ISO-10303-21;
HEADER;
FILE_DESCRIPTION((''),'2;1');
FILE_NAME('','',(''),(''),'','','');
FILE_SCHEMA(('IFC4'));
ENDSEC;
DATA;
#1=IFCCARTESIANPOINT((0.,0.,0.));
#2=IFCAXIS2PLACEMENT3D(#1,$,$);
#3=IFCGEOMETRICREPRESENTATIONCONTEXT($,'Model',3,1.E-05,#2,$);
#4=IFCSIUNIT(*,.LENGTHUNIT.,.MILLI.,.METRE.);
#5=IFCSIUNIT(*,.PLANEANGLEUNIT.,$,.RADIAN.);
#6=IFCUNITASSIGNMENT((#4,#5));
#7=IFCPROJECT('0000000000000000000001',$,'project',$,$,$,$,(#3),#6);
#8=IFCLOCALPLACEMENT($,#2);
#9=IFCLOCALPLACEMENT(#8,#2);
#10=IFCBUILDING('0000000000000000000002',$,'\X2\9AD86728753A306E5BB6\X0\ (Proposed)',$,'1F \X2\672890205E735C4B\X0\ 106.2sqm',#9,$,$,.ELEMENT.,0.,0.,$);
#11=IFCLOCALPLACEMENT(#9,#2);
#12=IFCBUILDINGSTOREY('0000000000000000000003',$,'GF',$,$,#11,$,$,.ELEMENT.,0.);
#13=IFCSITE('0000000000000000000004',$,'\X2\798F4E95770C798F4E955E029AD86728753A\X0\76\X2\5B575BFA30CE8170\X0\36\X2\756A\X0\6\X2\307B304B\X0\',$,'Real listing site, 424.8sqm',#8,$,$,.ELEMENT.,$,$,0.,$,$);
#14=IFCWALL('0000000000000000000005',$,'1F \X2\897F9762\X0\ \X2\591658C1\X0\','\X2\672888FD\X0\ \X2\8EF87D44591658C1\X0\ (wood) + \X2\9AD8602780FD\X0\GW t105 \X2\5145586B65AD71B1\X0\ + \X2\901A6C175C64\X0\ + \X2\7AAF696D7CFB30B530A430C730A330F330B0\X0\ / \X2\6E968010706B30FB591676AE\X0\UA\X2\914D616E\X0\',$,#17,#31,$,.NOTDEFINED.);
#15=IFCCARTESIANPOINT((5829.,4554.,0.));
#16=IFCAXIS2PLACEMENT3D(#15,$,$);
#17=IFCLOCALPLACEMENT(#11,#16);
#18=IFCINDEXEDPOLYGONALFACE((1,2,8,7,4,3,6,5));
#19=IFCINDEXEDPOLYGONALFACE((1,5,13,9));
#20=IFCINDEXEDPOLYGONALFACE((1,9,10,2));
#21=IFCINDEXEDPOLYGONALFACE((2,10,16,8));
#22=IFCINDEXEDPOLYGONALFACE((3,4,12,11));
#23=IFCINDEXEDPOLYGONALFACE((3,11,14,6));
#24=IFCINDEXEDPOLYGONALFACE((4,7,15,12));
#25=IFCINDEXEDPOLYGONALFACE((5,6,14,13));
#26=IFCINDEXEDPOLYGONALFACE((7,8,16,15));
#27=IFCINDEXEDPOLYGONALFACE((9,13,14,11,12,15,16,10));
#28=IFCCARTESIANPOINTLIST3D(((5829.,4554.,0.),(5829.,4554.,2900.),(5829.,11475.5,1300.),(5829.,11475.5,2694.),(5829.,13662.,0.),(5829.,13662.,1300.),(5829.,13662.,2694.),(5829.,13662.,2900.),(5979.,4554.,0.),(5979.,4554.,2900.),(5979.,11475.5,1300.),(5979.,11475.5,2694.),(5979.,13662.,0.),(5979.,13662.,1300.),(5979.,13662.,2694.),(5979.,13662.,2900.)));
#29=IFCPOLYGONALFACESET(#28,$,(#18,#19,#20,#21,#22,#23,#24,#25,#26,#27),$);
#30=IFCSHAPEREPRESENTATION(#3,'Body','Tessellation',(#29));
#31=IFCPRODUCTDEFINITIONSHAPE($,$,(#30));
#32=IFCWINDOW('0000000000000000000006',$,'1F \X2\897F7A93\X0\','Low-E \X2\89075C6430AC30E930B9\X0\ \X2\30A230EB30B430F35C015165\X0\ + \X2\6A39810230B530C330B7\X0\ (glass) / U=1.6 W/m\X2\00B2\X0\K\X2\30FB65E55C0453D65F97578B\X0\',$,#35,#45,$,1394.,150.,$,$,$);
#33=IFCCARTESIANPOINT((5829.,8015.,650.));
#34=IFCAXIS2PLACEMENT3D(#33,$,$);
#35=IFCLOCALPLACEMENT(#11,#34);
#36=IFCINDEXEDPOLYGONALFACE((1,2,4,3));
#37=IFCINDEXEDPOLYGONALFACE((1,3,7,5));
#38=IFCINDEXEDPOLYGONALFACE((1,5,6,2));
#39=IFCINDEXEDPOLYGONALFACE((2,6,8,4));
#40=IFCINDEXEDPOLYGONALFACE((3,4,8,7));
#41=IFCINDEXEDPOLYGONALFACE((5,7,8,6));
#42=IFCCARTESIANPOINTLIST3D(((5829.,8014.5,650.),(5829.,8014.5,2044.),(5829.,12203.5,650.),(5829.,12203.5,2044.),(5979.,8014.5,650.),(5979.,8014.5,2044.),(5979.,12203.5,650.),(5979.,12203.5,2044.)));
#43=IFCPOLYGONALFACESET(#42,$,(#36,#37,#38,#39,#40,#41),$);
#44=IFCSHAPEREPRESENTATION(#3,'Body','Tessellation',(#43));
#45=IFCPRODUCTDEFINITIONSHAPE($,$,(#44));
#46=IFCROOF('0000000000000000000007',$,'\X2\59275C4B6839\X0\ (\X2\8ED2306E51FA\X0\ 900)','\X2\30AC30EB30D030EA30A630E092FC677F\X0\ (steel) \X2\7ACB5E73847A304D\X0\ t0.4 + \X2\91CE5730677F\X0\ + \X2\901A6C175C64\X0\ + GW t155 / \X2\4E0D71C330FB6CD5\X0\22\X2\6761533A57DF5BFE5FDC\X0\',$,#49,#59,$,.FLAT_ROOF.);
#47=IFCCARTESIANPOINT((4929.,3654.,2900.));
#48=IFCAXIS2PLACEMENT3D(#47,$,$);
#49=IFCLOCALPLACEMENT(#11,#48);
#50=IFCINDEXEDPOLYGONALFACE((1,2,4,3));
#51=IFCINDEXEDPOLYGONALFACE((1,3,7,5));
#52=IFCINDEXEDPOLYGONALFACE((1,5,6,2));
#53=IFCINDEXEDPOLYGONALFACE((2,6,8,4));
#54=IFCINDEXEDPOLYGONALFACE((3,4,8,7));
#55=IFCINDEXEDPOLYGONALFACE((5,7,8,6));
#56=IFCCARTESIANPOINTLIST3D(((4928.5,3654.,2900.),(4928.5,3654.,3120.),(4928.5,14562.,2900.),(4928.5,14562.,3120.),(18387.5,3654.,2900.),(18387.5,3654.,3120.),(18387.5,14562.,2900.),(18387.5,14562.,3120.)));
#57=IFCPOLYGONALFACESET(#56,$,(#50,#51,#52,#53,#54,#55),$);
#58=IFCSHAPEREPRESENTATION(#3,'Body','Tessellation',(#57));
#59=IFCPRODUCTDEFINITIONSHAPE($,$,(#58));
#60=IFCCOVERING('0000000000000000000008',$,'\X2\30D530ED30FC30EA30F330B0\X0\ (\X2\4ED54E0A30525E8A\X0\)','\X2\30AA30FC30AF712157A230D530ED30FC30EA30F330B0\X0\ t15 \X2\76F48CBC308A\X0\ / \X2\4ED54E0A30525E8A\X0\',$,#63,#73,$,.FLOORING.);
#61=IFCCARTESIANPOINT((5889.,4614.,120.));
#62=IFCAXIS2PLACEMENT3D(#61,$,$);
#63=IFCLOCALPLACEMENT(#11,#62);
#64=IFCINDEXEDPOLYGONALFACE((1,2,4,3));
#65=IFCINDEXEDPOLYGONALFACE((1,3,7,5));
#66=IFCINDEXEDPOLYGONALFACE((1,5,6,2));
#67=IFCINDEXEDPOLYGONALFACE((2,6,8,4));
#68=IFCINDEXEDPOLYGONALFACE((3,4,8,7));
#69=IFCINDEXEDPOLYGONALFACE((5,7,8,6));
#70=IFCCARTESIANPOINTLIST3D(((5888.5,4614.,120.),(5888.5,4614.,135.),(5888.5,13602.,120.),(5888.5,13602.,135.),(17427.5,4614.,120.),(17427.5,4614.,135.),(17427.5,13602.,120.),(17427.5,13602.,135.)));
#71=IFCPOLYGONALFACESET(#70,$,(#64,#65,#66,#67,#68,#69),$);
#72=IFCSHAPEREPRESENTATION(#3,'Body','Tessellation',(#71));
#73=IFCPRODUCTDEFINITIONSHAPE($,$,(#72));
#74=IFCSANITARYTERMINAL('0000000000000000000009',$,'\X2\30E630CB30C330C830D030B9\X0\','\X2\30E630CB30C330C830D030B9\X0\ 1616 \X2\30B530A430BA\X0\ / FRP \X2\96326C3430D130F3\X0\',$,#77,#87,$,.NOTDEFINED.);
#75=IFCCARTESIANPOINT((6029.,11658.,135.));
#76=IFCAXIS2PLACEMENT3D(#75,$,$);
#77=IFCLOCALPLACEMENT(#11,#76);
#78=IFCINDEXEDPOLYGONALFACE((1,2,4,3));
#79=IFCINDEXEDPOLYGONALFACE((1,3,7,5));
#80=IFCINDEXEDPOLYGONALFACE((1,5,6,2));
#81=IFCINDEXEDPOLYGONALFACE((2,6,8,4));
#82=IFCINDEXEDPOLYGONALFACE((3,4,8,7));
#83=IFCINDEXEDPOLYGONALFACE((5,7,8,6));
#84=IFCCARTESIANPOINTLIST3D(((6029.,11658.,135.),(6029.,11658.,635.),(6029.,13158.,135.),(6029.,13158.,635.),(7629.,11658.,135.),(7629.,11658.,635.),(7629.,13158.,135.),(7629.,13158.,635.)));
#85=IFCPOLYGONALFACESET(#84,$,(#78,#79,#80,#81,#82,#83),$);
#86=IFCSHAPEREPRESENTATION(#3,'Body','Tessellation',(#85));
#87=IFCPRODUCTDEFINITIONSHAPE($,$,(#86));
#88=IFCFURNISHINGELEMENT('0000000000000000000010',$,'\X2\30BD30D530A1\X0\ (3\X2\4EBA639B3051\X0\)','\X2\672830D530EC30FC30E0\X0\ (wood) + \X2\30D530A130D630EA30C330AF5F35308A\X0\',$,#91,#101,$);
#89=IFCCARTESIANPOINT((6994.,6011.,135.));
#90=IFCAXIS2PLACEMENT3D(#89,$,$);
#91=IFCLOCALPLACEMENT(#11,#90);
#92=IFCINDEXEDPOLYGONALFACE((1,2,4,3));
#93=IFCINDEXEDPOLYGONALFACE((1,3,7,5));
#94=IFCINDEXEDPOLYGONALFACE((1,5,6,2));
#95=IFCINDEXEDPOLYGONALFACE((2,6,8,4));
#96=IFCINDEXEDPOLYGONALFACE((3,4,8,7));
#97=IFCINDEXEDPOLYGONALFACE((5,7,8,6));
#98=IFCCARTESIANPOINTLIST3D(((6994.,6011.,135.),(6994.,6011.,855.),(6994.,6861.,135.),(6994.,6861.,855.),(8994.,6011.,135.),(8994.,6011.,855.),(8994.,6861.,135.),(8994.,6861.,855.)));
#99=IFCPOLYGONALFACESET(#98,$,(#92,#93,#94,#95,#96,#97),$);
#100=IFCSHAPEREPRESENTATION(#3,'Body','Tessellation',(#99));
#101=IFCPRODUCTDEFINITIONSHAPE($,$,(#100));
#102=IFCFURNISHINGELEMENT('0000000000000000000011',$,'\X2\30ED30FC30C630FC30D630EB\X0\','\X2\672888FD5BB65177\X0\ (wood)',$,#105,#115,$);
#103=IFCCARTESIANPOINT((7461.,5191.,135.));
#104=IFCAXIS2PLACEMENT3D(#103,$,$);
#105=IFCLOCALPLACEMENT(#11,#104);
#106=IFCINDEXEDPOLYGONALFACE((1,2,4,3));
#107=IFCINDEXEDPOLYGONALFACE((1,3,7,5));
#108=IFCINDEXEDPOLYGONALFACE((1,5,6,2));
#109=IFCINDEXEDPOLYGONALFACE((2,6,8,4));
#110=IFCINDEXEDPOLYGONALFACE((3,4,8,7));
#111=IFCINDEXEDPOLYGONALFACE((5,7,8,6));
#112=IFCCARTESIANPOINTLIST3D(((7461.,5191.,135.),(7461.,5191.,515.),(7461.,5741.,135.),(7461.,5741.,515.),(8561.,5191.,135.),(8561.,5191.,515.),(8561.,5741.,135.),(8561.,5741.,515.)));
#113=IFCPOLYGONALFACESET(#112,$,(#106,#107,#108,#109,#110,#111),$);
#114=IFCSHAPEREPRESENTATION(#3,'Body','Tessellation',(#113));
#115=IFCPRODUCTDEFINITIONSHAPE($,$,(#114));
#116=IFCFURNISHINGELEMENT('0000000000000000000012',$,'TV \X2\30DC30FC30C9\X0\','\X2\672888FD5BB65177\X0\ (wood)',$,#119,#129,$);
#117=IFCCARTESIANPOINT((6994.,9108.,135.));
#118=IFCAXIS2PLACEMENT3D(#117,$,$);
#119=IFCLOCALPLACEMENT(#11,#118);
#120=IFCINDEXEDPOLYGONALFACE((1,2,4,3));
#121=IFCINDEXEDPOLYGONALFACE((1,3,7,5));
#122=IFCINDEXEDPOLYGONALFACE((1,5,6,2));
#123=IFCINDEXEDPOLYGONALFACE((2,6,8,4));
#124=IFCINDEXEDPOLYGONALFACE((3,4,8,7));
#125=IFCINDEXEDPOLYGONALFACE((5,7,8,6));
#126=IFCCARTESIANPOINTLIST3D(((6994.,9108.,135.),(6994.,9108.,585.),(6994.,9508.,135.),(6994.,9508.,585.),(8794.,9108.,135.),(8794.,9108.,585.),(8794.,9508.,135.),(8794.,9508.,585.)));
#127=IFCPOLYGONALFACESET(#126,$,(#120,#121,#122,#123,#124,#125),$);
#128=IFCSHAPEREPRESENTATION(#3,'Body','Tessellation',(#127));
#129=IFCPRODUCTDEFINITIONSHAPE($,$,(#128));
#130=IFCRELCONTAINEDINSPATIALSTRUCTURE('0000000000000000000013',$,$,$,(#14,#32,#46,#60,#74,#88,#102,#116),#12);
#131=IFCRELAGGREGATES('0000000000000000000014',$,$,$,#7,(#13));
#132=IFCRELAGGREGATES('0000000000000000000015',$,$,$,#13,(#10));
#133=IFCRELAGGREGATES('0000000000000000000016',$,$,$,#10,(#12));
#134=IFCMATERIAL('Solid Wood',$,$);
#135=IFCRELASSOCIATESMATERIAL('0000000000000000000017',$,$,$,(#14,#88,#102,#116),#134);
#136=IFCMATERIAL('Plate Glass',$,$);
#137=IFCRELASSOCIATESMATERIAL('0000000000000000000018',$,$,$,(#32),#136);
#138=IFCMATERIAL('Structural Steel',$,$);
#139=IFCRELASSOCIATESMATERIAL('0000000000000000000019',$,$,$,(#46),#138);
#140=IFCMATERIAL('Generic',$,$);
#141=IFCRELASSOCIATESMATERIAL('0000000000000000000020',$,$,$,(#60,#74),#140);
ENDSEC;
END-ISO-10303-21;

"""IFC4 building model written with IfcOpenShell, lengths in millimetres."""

from ifc_helpers import new_model, si_unit, frame, frame_2d, origin, place, context, project, spatial, rectangle, extrude, material, element, fill, save


model = new_model("IFC4")

# Units and contexts
model_context = context("Model", 3, precision=1e-05, world=origin())
ifc_project = project(units=[si_unit("LENGTHUNIT", "METRE", prefix="MILLI"), si_unit("PLANEANGLEUNIT", "RADIAN")], contexts=[model_context])

# Site, building, storey
site_placement = place(None, origin())
site = spatial("IfcSite", under=ifc_project, at=site_placement, Name="福井県福井市高木町76字寺ノ腰36番6ほか", ObjectType="Real listing site, 424.8sqm", CompositionType="ELEMENT", RefElevation=0.0)
building_placement = place(site_placement, origin())
building = spatial("IfcBuilding", under=site, at=building_placement, Name="高木町の家 (Proposed)", ObjectType="1F 木造平屋 106.2sqm", CompositionType="ELEMENT", ElevationOfRefHeight=0.0, ElevationOfTerrain=0.0)
storey_placement = place(building_placement, origin())
storey = spatial("IfcBuildingStorey", under=building, at=storey_placement, Name="GF", CompositionType="ELEMENT", Elevation=0.0)

# Shared definitions
ifc_material_1 = material(Name="Solid Wood")

# Shared definitions
ifc_material_2 = material(Name="Plate Glass")

# Wall, opening, window
wall_1_placement = place(storey_placement, frame((5829.0, 4554.0, 0.0)))
wall_1 = element("IfcWall", 1, at=wall_1_placement, inside=storey, material=ifc_material_1, Name="1F 西面 外壁", Description="木製 軸組外壁 (wood) + 高性能GW t105 充填断熱 + 通気層 + 窯業系サイディング / 準耐火・外皮UA配慮", PredefinedType="NOTDEFINED", context=model_context, shape_type="SweptSolid", body=[
    extrude(rectangle(XDim=150.0, YDim=9108.0, at=frame_2d((75.0, 4554.0))), frame((5829.0, 4554.0, 0.0)), (0.0, 0.0, 1.0), 2900.0),
])
opening_1_placement = place(storey_placement, frame((5829.0, 8015.0, 650.0)))
opening_1 = element("IfcOpeningElement", 2, at=opening_1_placement, cuts=wall_1, PredefinedType="NOTDEFINED", context=model_context, shape_type="SweptSolid", body=[
    extrude(rectangle(XDim=150.0, YDim=4189.0, at=frame_2d((75.0, 2094.0))), frame((5829.0, 8015.0, 650.0)), (0.0, 0.0, 1.0), 1394.0),
])
window_1_placement = place(storey_placement, frame((5829.0, 8015.0, 650.0)))
window_1 = element("IfcWindow", 3, at=window_1_placement, inside=storey, material=ifc_material_2, Name="1F 西窓", Description="Low-E 複層ガラス アルゴン封入 + 樹脂サッシ (glass) / U=1.6 W/m²K・日射取得型", OverallHeight=1394.0, OverallWidth=150.0, context=model_context, shape_type="SweptSolid", body=[
    extrude(rectangle(XDim=150.0, YDim=4189.0, at=frame_2d((75.0, 2094.0))), frame((5829.0, 8015.0, 650.0)), (0.0, 0.0, 1.0), 1394.0),
])
fill(opening_1, window_1)

# Roof
ifc_material_3 = material(Name="Structural Steel")
roof_placement = place(storey_placement, frame((4929.0, 3654.0, 2900.0)))
element("IfcRoof", 4, at=roof_placement, inside=storey, material=ifc_material_3, Name="大屋根 (軒の出 900)", Description="ガルバリウム鋼板 (steel) 立平葺き t0.4 + 野地板 + 通気層 + GW t155 / 不燃・法22条区域対応", PredefinedType="FLAT_ROOF", context=model_context, shape_type="SweptSolid", body=[
    extrude(rectangle(XDim=13459.0, YDim=10908.0, at=frame_2d((6729.0, 5454.0))), frame((4929.0, 3654.0, 2900.0)), (0.0, 0.0, 1.0), 220.0),
])

# Covering
ifc_material_4 = material(Name="Generic")
covering_placement = place(storey_placement, frame((5889.0, 4614.0, 120.0)))
element("IfcCovering", 5, at=covering_placement, inside=storey, material=ifc_material_4, Name="フローリング (仕上げ床)", Description="オーク無垢フローリング t15 直貼り / 仕上げ床", PredefinedType="FLOORING", context=model_context, shape_type="SweptSolid", body=[
    extrude(rectangle(XDim=11539.0, YDim=8988.0, at=frame_2d((5769.0, 4494.0))), frame((5889.0, 4614.0, 120.0)), (0.0, 0.0, 1.0), 15.0),
])

# Sanitary terminal
sanitary_terminal_placement = place(storey_placement, frame((6029.0, 11658.0, 135.0)))
element("IfcSanitaryTerminal", 6, at=sanitary_terminal_placement, inside=storey, material=ifc_material_4, Name="ユニットバス", Description="ユニットバス 1616 サイズ / FRP 防水パン", PredefinedType="NOTDEFINED", context=model_context, shape_type="SweptSolid", body=[
    extrude(rectangle(XDim=1600.0, YDim=1500.0, at=frame_2d((800.0, 750.0))), frame((6029.0, 11658.0, 135.0)), (0.0, 0.0, 1.0), 500.0),
])

# Furnishing elements
furnishing_1_placement = place(storey_placement, frame((6994.0, 6011.0, 135.0)))
element("IfcFurnishingElement", 7, at=furnishing_1_placement, inside=storey, material=ifc_material_1, Name="ソファ (3人掛け)", Description="木フレーム (wood) + ファブリック張り", context=model_context, shape_type="SweptSolid", body=[
    extrude(rectangle(XDim=2000.0, YDim=850.0, at=frame_2d((1000.0, 425.0))), frame((6994.0, 6011.0, 135.0)), (0.0, 0.0, 1.0), 720.0),
])
furnishing_2_placement = place(storey_placement, frame((7461.0, 5191.0, 135.0)))
element("IfcFurnishingElement", 8, at=furnishing_2_placement, inside=storey, material=ifc_material_1, Name="ローテーブル", Description="木製家具 (wood)", context=model_context, shape_type="SweptSolid", body=[
    extrude(rectangle(XDim=1100.0, YDim=550.0, at=frame_2d((550.0, 275.0))), frame((7461.0, 5191.0, 135.0)), (0.0, 0.0, 1.0), 380.0),
])
furnishing_3_placement = place(storey_placement, frame((6994.0, 9108.0, 135.0)))
element("IfcFurnishingElement", 9, at=furnishing_3_placement, inside=storey, material=ifc_material_1, Name="TV ボード", Description="木製家具 (wood)", context=model_context, shape_type="SweptSolid", body=[
    extrude(rectangle(XDim=1800.0, YDim=400.0, at=frame_2d((900.0, 200.0))), frame((6994.0, 9108.0, 135.0)), (0.0, 0.0, 1.0), 450.0),
])

save(model, "model.ifc")
